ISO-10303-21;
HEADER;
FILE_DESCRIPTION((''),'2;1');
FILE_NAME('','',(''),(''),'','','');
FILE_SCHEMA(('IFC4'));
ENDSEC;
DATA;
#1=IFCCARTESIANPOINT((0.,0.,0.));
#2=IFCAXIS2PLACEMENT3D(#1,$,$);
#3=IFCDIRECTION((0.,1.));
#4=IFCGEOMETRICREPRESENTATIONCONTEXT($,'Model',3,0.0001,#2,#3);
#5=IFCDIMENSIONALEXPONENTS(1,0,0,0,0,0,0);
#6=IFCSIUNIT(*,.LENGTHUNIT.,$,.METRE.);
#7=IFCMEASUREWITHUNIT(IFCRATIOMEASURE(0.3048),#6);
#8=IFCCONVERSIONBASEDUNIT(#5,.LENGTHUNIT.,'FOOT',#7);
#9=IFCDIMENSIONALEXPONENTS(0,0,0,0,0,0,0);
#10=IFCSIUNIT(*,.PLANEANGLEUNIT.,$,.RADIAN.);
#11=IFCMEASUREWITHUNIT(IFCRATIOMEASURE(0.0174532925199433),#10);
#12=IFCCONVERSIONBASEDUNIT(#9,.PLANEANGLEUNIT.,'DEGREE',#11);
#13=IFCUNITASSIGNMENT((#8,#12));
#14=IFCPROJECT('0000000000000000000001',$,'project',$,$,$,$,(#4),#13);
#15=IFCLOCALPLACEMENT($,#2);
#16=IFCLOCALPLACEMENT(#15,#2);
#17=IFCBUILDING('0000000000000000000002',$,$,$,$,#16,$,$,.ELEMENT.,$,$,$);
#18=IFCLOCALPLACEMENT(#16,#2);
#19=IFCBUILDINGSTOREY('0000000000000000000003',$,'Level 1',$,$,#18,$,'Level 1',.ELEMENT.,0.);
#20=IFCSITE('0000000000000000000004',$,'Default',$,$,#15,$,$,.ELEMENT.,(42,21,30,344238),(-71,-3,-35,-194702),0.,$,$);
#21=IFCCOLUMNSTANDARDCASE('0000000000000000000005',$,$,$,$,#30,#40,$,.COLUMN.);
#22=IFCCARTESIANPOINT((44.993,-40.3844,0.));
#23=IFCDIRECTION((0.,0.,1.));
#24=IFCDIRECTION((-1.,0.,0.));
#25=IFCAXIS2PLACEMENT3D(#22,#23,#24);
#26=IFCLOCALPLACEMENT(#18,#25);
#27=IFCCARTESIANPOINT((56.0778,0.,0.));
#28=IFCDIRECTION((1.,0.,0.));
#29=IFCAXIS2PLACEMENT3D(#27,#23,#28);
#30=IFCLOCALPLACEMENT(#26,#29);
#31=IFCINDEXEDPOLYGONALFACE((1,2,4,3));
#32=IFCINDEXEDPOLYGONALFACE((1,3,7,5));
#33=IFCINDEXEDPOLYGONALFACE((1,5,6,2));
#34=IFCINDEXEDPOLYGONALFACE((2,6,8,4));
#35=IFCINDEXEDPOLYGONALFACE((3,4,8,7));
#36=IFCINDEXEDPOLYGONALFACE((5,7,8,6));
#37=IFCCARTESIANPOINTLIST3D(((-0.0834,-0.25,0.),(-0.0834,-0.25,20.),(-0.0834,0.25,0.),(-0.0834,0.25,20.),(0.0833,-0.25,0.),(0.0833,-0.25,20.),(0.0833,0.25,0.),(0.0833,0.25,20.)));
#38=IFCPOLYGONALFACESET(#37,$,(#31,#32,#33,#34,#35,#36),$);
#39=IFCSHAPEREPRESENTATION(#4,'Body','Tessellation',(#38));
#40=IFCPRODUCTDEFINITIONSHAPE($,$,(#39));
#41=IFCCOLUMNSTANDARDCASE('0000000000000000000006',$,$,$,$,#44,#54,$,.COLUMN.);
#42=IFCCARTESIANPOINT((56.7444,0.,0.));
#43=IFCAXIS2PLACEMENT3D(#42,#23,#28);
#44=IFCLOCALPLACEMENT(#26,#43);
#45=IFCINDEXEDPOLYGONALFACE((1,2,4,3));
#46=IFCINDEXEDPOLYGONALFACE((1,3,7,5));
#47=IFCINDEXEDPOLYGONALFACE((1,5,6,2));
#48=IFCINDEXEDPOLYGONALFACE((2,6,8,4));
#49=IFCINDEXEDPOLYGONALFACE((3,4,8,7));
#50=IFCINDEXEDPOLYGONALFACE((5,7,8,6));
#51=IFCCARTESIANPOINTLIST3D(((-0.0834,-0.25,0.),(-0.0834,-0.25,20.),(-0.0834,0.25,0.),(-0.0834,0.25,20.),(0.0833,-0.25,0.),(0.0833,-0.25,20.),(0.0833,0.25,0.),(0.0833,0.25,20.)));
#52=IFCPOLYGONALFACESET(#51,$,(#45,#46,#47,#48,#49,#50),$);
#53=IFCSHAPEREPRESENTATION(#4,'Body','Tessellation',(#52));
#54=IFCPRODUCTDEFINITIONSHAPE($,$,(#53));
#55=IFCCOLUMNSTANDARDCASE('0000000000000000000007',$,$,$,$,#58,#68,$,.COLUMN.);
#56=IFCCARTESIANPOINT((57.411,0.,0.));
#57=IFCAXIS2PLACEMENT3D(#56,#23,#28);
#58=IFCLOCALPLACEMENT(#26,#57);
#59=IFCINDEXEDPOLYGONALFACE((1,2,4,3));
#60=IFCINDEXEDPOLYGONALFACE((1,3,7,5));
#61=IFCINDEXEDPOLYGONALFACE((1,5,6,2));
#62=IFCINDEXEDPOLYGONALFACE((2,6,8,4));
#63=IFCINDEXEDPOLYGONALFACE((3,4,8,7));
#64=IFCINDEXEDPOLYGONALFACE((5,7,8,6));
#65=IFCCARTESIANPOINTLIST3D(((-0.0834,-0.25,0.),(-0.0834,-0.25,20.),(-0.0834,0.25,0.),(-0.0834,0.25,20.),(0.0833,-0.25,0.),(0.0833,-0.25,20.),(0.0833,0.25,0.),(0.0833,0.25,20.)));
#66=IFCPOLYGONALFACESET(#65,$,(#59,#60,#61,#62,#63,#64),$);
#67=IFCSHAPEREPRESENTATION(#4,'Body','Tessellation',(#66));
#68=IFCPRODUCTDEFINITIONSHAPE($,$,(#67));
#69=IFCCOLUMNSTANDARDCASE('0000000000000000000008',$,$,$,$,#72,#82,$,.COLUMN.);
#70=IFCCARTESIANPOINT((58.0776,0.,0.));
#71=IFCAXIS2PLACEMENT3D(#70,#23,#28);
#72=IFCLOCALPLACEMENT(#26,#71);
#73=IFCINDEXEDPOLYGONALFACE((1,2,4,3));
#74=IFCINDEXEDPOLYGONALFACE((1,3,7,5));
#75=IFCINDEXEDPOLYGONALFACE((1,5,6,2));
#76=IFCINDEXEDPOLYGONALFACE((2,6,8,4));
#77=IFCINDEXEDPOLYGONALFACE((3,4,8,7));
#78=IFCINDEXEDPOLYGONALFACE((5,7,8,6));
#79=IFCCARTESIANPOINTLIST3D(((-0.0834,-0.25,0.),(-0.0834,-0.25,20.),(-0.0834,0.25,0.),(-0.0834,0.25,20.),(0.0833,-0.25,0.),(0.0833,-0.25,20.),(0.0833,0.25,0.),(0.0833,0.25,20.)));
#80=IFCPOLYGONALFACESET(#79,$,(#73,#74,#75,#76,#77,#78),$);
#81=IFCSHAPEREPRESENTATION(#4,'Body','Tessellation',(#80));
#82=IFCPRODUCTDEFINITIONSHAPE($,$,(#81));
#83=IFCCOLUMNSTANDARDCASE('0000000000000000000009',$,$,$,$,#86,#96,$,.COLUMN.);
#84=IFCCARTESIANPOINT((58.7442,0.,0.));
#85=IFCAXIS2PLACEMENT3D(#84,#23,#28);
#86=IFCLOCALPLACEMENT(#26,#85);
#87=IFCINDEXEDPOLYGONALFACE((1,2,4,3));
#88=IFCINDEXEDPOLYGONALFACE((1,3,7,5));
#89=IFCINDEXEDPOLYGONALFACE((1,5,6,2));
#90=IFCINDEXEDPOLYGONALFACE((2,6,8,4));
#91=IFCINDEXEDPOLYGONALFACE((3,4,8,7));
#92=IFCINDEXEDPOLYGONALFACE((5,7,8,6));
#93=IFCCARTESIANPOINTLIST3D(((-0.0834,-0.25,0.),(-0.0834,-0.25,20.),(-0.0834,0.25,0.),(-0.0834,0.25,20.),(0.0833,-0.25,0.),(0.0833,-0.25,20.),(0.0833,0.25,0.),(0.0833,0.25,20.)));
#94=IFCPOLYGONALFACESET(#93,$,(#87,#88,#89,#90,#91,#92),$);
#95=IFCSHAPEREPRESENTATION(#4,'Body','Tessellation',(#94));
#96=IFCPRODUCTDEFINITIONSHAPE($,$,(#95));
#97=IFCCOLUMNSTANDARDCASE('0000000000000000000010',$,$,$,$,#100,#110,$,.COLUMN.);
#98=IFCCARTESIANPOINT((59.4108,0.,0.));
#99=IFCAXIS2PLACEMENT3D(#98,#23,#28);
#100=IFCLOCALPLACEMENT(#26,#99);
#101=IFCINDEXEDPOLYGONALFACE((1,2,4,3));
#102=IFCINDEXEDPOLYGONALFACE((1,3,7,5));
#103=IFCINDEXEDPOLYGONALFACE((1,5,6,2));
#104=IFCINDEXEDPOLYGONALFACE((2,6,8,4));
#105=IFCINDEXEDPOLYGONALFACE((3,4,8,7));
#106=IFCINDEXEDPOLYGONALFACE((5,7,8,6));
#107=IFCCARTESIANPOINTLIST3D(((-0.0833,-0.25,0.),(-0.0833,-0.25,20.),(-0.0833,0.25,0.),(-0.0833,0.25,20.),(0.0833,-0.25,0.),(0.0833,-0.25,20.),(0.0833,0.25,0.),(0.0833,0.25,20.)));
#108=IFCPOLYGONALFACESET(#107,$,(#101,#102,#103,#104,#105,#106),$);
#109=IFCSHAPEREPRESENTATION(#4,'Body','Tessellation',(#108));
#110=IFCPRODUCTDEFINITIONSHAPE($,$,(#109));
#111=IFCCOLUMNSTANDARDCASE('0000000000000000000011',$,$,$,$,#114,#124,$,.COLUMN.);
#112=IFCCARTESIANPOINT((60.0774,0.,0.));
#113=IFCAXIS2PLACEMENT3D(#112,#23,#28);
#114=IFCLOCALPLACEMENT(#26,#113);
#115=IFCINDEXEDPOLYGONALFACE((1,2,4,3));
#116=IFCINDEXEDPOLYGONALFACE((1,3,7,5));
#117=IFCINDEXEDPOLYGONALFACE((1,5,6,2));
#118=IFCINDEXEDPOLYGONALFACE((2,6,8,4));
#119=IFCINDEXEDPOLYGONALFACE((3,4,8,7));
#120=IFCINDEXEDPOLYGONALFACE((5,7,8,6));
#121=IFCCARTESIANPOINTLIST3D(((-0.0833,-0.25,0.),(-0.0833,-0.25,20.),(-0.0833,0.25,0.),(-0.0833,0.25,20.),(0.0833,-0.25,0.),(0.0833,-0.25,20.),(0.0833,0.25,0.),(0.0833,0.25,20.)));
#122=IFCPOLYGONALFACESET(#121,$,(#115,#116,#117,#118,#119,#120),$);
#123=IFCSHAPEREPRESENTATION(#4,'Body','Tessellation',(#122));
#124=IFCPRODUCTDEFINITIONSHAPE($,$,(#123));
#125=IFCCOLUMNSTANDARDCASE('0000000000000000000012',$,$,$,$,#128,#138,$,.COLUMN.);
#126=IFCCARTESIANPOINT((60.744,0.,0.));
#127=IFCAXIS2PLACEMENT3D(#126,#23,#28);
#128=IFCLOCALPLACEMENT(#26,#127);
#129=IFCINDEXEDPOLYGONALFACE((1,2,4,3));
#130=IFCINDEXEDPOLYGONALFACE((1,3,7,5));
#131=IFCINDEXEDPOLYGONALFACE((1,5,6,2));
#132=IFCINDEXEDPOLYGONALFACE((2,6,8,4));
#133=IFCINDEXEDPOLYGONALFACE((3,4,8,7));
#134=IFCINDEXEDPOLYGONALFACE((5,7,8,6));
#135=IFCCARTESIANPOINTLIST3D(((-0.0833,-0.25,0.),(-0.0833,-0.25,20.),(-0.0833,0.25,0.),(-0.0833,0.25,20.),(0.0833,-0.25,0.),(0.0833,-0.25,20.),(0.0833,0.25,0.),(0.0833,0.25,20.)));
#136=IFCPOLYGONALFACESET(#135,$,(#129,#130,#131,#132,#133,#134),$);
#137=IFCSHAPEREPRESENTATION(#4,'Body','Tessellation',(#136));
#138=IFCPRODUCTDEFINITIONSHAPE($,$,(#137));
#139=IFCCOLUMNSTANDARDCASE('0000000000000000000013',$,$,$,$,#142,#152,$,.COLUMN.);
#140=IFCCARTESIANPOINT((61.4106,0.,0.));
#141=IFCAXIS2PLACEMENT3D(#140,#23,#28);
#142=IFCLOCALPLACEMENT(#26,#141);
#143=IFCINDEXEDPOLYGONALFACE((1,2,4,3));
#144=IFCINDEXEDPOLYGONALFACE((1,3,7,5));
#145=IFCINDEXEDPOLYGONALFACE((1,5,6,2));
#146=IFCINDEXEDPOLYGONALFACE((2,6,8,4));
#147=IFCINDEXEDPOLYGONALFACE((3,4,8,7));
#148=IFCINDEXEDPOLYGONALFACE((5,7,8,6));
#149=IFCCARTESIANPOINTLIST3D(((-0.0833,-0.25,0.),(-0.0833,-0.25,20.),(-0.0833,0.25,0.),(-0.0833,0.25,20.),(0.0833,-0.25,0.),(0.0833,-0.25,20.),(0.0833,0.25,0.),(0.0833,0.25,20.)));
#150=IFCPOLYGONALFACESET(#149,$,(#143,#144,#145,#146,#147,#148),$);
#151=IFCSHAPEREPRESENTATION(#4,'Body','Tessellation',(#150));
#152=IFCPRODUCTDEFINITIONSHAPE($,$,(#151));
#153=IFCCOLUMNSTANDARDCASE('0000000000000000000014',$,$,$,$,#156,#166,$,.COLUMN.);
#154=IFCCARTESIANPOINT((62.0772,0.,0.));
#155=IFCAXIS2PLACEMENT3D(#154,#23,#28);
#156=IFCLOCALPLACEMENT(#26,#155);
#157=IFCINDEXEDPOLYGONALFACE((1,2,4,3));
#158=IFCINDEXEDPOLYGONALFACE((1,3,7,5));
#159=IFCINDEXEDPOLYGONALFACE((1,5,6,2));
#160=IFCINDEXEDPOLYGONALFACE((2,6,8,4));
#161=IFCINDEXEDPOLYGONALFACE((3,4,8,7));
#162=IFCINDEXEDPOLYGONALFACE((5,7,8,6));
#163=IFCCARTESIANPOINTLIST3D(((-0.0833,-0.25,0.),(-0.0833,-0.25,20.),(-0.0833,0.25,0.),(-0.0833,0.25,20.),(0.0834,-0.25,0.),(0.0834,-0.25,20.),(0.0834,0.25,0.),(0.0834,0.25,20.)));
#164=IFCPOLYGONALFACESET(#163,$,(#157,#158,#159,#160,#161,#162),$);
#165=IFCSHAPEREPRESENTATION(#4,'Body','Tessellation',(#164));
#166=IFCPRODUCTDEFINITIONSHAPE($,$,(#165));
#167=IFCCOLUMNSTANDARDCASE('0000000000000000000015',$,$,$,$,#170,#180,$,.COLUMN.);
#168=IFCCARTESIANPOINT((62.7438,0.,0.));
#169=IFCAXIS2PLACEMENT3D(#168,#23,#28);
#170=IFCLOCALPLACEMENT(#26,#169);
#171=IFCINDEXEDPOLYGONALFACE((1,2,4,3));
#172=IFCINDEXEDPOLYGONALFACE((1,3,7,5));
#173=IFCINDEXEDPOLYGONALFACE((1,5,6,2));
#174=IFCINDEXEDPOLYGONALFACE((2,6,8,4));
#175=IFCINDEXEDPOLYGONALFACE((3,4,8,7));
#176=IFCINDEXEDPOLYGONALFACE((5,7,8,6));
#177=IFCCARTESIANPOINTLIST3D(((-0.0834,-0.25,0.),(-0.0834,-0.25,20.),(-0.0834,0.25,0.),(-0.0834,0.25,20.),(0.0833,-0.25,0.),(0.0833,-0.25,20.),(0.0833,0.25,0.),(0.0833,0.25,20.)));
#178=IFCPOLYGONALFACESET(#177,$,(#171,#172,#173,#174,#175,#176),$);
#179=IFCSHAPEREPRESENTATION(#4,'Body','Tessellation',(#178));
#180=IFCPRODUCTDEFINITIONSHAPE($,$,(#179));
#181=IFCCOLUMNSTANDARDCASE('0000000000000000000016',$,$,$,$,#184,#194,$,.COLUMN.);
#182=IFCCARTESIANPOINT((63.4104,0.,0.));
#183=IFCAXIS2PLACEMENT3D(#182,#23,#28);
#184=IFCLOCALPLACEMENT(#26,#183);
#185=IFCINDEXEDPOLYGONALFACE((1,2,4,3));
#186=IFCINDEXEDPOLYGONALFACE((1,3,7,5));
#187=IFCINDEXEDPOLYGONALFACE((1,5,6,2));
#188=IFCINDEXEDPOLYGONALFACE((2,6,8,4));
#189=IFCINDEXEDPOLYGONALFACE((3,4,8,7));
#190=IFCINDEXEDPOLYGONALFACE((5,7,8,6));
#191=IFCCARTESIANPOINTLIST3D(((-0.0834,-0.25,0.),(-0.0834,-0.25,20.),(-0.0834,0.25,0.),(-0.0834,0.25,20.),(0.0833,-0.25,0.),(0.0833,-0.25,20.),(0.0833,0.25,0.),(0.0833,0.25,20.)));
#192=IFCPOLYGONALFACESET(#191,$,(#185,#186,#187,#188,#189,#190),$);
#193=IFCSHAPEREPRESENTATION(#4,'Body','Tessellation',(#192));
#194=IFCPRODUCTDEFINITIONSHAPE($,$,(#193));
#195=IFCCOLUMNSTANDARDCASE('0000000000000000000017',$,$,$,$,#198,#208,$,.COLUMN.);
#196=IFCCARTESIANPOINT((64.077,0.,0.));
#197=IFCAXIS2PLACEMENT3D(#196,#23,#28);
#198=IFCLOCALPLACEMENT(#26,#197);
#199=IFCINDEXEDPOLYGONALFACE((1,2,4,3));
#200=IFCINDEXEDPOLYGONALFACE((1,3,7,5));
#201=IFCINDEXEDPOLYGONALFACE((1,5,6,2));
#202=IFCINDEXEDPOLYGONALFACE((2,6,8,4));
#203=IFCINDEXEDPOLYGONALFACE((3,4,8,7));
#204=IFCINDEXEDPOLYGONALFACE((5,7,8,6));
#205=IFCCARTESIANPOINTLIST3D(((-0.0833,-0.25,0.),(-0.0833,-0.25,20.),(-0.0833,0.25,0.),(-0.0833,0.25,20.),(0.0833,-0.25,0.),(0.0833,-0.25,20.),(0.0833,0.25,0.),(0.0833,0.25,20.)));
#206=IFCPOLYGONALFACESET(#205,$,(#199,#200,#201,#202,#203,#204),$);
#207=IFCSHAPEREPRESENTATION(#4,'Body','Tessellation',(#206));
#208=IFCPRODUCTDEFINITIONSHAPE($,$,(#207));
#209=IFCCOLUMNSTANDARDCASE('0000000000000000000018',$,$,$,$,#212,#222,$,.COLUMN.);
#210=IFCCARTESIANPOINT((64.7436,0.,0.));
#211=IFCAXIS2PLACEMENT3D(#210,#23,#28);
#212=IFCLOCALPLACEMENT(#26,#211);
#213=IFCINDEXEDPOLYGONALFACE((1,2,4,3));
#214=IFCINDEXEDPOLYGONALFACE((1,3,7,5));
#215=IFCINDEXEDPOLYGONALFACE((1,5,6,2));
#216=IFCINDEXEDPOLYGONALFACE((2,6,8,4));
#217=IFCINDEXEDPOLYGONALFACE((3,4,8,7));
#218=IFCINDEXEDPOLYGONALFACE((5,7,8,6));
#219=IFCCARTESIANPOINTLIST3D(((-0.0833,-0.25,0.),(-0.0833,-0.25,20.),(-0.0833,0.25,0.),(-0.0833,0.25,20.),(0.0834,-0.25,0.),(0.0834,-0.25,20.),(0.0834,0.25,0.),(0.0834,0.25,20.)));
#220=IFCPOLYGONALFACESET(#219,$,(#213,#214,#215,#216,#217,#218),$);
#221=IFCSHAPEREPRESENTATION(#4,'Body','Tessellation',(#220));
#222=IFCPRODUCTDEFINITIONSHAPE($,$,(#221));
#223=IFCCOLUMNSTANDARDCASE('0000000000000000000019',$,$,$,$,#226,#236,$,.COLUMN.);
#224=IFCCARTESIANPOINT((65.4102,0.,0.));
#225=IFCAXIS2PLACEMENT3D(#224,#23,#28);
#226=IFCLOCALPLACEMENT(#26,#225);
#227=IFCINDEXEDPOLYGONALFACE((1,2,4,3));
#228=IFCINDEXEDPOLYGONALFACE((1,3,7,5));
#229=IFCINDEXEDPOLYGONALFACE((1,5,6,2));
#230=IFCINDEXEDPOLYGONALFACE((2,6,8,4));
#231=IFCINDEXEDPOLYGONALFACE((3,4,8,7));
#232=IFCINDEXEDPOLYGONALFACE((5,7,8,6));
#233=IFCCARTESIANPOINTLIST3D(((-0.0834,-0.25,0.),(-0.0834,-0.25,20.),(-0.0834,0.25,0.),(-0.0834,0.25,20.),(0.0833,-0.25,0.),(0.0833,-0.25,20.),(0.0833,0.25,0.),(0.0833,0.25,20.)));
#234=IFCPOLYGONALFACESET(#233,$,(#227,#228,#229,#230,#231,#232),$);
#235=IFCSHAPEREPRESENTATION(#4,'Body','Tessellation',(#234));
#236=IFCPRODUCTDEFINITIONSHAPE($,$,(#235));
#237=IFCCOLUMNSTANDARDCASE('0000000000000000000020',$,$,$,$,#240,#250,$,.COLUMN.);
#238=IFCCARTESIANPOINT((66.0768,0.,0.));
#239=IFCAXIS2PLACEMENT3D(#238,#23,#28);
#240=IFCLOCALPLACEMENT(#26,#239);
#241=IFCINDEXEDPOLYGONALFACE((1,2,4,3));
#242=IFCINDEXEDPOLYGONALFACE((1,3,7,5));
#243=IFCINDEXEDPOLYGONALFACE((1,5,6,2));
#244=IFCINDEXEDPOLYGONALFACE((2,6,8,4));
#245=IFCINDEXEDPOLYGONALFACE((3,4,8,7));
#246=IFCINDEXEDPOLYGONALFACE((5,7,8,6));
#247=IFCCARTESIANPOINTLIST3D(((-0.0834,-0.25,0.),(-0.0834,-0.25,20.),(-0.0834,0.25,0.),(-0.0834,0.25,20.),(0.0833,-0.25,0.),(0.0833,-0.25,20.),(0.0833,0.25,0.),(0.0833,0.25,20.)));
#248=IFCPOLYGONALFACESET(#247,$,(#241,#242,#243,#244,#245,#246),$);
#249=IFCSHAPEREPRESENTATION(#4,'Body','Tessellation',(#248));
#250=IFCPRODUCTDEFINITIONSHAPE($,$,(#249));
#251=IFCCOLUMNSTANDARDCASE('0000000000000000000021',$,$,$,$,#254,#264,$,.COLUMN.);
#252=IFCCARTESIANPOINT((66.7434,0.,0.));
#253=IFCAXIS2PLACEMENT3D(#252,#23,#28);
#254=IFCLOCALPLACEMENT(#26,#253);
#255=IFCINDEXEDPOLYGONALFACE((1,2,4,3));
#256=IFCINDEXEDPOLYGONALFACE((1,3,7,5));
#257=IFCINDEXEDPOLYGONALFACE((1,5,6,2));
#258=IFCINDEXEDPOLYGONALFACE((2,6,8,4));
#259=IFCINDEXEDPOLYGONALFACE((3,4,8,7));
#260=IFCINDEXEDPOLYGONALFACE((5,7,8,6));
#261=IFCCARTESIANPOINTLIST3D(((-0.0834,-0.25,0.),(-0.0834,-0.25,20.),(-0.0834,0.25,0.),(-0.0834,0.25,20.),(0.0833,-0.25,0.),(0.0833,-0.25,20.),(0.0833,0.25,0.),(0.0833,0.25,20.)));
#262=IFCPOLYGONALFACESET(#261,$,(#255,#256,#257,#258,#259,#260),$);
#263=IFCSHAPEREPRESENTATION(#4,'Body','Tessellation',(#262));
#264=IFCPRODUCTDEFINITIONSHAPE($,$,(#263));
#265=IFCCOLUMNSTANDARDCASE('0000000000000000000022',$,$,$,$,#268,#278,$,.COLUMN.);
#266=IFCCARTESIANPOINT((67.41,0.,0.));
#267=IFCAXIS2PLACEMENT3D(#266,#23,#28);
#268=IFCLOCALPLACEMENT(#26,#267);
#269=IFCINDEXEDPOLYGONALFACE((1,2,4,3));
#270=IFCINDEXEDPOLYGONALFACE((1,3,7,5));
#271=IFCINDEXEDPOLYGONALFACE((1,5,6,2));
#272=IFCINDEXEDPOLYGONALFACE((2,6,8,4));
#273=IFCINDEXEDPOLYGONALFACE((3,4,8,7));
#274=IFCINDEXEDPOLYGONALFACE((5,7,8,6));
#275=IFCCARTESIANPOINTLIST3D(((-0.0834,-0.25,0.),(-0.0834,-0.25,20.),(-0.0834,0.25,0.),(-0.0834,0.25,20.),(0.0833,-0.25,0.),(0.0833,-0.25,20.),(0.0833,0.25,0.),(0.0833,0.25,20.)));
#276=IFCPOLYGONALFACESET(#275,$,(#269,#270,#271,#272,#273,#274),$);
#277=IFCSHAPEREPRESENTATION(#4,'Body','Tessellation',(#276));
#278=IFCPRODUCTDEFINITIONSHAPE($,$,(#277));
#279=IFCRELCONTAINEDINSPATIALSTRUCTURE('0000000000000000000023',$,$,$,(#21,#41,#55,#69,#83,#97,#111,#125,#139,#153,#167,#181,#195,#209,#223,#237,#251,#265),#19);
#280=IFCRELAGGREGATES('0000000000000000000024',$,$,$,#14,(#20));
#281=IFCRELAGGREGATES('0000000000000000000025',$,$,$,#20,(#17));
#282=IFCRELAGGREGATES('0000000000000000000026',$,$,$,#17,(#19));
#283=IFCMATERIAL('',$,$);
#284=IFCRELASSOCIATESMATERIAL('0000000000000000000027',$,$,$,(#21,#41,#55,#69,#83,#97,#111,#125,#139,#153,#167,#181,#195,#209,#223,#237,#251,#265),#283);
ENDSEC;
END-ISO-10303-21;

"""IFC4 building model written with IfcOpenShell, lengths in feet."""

from ifc_helpers import new_model, entity, si_unit, converted_unit, direction, frame, origin, place, context, project, spatial, rectangle, extrude, material, element, save


model = new_model("IFC4")

# Units and contexts
model_context = context("Model", 3, precision=0.0001, world=origin(), true_north=direction((0.0, 1.0)))
ifc_project = project(units=[converted_unit("LENGTHUNIT", "FOOT", entity("IfcRatioMeasure", 0.3048), si_unit("LENGTHUNIT", "METRE"), dimensions=[1, 0, 0, 0, 0, 0, 0]), converted_unit("PLANEANGLEUNIT", "DEGREE", entity("IfcRatioMeasure", 0.0174532925199433), si_unit("PLANEANGLEUNIT", "RADIAN"), dimensions=[0, 0, 0, 0, 0, 0, 0])], contexts=[model_context])

# Site, building, storey
site_placement = place(None, origin())
site = spatial("IfcSite", under=ifc_project, at=site_placement, Name="Default", CompositionType="ELEMENT", RefLatitude=(42, 21, 30, 344238), RefLongitude=(-71, -3, -35, -194702), RefElevation=0.0)
building_placement = place(site_placement, origin())
building = spatial("IfcBuilding", under=site, at=building_placement, CompositionType="ELEMENT")
storey_placement = place(building_placement, origin())
storey = spatial("IfcBuildingStorey", under=building, at=storey_placement, Name="Level 1", LongName="Level 1", CompositionType="ELEMENT", Elevation=0.0)

# Columns
ifc_material_1 = material(Name="")
placement = place(storey_placement, frame((44.993, -40.3844, 0.0), z_axis=(0.0, 0.0, 1.0), x_axis=(-1.0, 0.0, 0.0)))
for number, where, z_axis, x_axis in (
    (1, (56.0778, 0.0, 0.0), (0.0, 0.0, 1.0), (1.0, 0.0, 0.0)),
    (2, (56.7444, 0.0, 0.0), (0.0, 0.0, 1.0), (1.0, 0.0, 0.0)),
    (3, (57.411, 0.0, 0.0), (0.0, 0.0, 1.0), (1.0, 0.0, 0.0)),
    (4, (58.0776, 0.0, 0.0), (0.0, 0.0, 1.0), (1.0, 0.0, 0.0)),
    (5, (58.7442, 0.0, 0.0), (0.0, 0.0, 1.0), (1.0, 0.0, 0.0)),
    (6, (59.4108, 0.0, 0.0), (0.0, 0.0, 1.0), (1.0, 0.0, 0.0)),
    (7, (60.0774, 0.0, 0.0), (0.0, 0.0, 1.0), (1.0, 0.0, 0.0)),
    (8, (60.744, 0.0, 0.0), (0.0, 0.0, 1.0), (1.0, 0.0, 0.0)),
    (9, (61.4106, 0.0, 0.0), (0.0, 0.0, 1.0), (1.0, 0.0, 0.0)),
    (10, (62.0772, 0.0, 0.0), (0.0, 0.0, 1.0), (1.0, 0.0, 0.0)),
    (11, (62.7438, 0.0, 0.0), (0.0, 0.0, 1.0), (1.0, 0.0, 0.0)),
    (12, (63.4104, 0.0, 0.0), (0.0, 0.0, 1.0), (1.0, 0.0, 0.0)),
    (13, (64.077, 0.0, 0.0), (0.0, 0.0, 1.0), (1.0, 0.0, 0.0)),
    (14, (64.7436, 0.0, 0.0), (0.0, 0.0, 1.0), (1.0, 0.0, 0.0)),
    (15, (65.4102, 0.0, 0.0), (0.0, 0.0, 1.0), (1.0, 0.0, 0.0)),
    (16, (66.0768, 0.0, 0.0), (0.0, 0.0, 1.0), (1.0, 0.0, 0.0)),
    (17, (66.7434, 0.0, 0.0), (0.0, 0.0, 1.0), (1.0, 0.0, 0.0)),
    (18, (67.41, 0.0, 0.0), (0.0, 0.0, 1.0), (1.0, 0.0, 0.0)),
):
    element("IfcColumnStandardCase", number, at=place(placement, frame(where, z_axis=z_axis, x_axis=x_axis)), inside=storey, material=ifc_material_1, PredefinedType="COLUMN", context=model_context, shape_type="SweptSolid", body=[
        extrude(rectangle(XDim=0.1667, YDim=0.5), origin(), (0.0, 0.0, 1.0), 20.0),
    ])

save(model, "model.ifc")
